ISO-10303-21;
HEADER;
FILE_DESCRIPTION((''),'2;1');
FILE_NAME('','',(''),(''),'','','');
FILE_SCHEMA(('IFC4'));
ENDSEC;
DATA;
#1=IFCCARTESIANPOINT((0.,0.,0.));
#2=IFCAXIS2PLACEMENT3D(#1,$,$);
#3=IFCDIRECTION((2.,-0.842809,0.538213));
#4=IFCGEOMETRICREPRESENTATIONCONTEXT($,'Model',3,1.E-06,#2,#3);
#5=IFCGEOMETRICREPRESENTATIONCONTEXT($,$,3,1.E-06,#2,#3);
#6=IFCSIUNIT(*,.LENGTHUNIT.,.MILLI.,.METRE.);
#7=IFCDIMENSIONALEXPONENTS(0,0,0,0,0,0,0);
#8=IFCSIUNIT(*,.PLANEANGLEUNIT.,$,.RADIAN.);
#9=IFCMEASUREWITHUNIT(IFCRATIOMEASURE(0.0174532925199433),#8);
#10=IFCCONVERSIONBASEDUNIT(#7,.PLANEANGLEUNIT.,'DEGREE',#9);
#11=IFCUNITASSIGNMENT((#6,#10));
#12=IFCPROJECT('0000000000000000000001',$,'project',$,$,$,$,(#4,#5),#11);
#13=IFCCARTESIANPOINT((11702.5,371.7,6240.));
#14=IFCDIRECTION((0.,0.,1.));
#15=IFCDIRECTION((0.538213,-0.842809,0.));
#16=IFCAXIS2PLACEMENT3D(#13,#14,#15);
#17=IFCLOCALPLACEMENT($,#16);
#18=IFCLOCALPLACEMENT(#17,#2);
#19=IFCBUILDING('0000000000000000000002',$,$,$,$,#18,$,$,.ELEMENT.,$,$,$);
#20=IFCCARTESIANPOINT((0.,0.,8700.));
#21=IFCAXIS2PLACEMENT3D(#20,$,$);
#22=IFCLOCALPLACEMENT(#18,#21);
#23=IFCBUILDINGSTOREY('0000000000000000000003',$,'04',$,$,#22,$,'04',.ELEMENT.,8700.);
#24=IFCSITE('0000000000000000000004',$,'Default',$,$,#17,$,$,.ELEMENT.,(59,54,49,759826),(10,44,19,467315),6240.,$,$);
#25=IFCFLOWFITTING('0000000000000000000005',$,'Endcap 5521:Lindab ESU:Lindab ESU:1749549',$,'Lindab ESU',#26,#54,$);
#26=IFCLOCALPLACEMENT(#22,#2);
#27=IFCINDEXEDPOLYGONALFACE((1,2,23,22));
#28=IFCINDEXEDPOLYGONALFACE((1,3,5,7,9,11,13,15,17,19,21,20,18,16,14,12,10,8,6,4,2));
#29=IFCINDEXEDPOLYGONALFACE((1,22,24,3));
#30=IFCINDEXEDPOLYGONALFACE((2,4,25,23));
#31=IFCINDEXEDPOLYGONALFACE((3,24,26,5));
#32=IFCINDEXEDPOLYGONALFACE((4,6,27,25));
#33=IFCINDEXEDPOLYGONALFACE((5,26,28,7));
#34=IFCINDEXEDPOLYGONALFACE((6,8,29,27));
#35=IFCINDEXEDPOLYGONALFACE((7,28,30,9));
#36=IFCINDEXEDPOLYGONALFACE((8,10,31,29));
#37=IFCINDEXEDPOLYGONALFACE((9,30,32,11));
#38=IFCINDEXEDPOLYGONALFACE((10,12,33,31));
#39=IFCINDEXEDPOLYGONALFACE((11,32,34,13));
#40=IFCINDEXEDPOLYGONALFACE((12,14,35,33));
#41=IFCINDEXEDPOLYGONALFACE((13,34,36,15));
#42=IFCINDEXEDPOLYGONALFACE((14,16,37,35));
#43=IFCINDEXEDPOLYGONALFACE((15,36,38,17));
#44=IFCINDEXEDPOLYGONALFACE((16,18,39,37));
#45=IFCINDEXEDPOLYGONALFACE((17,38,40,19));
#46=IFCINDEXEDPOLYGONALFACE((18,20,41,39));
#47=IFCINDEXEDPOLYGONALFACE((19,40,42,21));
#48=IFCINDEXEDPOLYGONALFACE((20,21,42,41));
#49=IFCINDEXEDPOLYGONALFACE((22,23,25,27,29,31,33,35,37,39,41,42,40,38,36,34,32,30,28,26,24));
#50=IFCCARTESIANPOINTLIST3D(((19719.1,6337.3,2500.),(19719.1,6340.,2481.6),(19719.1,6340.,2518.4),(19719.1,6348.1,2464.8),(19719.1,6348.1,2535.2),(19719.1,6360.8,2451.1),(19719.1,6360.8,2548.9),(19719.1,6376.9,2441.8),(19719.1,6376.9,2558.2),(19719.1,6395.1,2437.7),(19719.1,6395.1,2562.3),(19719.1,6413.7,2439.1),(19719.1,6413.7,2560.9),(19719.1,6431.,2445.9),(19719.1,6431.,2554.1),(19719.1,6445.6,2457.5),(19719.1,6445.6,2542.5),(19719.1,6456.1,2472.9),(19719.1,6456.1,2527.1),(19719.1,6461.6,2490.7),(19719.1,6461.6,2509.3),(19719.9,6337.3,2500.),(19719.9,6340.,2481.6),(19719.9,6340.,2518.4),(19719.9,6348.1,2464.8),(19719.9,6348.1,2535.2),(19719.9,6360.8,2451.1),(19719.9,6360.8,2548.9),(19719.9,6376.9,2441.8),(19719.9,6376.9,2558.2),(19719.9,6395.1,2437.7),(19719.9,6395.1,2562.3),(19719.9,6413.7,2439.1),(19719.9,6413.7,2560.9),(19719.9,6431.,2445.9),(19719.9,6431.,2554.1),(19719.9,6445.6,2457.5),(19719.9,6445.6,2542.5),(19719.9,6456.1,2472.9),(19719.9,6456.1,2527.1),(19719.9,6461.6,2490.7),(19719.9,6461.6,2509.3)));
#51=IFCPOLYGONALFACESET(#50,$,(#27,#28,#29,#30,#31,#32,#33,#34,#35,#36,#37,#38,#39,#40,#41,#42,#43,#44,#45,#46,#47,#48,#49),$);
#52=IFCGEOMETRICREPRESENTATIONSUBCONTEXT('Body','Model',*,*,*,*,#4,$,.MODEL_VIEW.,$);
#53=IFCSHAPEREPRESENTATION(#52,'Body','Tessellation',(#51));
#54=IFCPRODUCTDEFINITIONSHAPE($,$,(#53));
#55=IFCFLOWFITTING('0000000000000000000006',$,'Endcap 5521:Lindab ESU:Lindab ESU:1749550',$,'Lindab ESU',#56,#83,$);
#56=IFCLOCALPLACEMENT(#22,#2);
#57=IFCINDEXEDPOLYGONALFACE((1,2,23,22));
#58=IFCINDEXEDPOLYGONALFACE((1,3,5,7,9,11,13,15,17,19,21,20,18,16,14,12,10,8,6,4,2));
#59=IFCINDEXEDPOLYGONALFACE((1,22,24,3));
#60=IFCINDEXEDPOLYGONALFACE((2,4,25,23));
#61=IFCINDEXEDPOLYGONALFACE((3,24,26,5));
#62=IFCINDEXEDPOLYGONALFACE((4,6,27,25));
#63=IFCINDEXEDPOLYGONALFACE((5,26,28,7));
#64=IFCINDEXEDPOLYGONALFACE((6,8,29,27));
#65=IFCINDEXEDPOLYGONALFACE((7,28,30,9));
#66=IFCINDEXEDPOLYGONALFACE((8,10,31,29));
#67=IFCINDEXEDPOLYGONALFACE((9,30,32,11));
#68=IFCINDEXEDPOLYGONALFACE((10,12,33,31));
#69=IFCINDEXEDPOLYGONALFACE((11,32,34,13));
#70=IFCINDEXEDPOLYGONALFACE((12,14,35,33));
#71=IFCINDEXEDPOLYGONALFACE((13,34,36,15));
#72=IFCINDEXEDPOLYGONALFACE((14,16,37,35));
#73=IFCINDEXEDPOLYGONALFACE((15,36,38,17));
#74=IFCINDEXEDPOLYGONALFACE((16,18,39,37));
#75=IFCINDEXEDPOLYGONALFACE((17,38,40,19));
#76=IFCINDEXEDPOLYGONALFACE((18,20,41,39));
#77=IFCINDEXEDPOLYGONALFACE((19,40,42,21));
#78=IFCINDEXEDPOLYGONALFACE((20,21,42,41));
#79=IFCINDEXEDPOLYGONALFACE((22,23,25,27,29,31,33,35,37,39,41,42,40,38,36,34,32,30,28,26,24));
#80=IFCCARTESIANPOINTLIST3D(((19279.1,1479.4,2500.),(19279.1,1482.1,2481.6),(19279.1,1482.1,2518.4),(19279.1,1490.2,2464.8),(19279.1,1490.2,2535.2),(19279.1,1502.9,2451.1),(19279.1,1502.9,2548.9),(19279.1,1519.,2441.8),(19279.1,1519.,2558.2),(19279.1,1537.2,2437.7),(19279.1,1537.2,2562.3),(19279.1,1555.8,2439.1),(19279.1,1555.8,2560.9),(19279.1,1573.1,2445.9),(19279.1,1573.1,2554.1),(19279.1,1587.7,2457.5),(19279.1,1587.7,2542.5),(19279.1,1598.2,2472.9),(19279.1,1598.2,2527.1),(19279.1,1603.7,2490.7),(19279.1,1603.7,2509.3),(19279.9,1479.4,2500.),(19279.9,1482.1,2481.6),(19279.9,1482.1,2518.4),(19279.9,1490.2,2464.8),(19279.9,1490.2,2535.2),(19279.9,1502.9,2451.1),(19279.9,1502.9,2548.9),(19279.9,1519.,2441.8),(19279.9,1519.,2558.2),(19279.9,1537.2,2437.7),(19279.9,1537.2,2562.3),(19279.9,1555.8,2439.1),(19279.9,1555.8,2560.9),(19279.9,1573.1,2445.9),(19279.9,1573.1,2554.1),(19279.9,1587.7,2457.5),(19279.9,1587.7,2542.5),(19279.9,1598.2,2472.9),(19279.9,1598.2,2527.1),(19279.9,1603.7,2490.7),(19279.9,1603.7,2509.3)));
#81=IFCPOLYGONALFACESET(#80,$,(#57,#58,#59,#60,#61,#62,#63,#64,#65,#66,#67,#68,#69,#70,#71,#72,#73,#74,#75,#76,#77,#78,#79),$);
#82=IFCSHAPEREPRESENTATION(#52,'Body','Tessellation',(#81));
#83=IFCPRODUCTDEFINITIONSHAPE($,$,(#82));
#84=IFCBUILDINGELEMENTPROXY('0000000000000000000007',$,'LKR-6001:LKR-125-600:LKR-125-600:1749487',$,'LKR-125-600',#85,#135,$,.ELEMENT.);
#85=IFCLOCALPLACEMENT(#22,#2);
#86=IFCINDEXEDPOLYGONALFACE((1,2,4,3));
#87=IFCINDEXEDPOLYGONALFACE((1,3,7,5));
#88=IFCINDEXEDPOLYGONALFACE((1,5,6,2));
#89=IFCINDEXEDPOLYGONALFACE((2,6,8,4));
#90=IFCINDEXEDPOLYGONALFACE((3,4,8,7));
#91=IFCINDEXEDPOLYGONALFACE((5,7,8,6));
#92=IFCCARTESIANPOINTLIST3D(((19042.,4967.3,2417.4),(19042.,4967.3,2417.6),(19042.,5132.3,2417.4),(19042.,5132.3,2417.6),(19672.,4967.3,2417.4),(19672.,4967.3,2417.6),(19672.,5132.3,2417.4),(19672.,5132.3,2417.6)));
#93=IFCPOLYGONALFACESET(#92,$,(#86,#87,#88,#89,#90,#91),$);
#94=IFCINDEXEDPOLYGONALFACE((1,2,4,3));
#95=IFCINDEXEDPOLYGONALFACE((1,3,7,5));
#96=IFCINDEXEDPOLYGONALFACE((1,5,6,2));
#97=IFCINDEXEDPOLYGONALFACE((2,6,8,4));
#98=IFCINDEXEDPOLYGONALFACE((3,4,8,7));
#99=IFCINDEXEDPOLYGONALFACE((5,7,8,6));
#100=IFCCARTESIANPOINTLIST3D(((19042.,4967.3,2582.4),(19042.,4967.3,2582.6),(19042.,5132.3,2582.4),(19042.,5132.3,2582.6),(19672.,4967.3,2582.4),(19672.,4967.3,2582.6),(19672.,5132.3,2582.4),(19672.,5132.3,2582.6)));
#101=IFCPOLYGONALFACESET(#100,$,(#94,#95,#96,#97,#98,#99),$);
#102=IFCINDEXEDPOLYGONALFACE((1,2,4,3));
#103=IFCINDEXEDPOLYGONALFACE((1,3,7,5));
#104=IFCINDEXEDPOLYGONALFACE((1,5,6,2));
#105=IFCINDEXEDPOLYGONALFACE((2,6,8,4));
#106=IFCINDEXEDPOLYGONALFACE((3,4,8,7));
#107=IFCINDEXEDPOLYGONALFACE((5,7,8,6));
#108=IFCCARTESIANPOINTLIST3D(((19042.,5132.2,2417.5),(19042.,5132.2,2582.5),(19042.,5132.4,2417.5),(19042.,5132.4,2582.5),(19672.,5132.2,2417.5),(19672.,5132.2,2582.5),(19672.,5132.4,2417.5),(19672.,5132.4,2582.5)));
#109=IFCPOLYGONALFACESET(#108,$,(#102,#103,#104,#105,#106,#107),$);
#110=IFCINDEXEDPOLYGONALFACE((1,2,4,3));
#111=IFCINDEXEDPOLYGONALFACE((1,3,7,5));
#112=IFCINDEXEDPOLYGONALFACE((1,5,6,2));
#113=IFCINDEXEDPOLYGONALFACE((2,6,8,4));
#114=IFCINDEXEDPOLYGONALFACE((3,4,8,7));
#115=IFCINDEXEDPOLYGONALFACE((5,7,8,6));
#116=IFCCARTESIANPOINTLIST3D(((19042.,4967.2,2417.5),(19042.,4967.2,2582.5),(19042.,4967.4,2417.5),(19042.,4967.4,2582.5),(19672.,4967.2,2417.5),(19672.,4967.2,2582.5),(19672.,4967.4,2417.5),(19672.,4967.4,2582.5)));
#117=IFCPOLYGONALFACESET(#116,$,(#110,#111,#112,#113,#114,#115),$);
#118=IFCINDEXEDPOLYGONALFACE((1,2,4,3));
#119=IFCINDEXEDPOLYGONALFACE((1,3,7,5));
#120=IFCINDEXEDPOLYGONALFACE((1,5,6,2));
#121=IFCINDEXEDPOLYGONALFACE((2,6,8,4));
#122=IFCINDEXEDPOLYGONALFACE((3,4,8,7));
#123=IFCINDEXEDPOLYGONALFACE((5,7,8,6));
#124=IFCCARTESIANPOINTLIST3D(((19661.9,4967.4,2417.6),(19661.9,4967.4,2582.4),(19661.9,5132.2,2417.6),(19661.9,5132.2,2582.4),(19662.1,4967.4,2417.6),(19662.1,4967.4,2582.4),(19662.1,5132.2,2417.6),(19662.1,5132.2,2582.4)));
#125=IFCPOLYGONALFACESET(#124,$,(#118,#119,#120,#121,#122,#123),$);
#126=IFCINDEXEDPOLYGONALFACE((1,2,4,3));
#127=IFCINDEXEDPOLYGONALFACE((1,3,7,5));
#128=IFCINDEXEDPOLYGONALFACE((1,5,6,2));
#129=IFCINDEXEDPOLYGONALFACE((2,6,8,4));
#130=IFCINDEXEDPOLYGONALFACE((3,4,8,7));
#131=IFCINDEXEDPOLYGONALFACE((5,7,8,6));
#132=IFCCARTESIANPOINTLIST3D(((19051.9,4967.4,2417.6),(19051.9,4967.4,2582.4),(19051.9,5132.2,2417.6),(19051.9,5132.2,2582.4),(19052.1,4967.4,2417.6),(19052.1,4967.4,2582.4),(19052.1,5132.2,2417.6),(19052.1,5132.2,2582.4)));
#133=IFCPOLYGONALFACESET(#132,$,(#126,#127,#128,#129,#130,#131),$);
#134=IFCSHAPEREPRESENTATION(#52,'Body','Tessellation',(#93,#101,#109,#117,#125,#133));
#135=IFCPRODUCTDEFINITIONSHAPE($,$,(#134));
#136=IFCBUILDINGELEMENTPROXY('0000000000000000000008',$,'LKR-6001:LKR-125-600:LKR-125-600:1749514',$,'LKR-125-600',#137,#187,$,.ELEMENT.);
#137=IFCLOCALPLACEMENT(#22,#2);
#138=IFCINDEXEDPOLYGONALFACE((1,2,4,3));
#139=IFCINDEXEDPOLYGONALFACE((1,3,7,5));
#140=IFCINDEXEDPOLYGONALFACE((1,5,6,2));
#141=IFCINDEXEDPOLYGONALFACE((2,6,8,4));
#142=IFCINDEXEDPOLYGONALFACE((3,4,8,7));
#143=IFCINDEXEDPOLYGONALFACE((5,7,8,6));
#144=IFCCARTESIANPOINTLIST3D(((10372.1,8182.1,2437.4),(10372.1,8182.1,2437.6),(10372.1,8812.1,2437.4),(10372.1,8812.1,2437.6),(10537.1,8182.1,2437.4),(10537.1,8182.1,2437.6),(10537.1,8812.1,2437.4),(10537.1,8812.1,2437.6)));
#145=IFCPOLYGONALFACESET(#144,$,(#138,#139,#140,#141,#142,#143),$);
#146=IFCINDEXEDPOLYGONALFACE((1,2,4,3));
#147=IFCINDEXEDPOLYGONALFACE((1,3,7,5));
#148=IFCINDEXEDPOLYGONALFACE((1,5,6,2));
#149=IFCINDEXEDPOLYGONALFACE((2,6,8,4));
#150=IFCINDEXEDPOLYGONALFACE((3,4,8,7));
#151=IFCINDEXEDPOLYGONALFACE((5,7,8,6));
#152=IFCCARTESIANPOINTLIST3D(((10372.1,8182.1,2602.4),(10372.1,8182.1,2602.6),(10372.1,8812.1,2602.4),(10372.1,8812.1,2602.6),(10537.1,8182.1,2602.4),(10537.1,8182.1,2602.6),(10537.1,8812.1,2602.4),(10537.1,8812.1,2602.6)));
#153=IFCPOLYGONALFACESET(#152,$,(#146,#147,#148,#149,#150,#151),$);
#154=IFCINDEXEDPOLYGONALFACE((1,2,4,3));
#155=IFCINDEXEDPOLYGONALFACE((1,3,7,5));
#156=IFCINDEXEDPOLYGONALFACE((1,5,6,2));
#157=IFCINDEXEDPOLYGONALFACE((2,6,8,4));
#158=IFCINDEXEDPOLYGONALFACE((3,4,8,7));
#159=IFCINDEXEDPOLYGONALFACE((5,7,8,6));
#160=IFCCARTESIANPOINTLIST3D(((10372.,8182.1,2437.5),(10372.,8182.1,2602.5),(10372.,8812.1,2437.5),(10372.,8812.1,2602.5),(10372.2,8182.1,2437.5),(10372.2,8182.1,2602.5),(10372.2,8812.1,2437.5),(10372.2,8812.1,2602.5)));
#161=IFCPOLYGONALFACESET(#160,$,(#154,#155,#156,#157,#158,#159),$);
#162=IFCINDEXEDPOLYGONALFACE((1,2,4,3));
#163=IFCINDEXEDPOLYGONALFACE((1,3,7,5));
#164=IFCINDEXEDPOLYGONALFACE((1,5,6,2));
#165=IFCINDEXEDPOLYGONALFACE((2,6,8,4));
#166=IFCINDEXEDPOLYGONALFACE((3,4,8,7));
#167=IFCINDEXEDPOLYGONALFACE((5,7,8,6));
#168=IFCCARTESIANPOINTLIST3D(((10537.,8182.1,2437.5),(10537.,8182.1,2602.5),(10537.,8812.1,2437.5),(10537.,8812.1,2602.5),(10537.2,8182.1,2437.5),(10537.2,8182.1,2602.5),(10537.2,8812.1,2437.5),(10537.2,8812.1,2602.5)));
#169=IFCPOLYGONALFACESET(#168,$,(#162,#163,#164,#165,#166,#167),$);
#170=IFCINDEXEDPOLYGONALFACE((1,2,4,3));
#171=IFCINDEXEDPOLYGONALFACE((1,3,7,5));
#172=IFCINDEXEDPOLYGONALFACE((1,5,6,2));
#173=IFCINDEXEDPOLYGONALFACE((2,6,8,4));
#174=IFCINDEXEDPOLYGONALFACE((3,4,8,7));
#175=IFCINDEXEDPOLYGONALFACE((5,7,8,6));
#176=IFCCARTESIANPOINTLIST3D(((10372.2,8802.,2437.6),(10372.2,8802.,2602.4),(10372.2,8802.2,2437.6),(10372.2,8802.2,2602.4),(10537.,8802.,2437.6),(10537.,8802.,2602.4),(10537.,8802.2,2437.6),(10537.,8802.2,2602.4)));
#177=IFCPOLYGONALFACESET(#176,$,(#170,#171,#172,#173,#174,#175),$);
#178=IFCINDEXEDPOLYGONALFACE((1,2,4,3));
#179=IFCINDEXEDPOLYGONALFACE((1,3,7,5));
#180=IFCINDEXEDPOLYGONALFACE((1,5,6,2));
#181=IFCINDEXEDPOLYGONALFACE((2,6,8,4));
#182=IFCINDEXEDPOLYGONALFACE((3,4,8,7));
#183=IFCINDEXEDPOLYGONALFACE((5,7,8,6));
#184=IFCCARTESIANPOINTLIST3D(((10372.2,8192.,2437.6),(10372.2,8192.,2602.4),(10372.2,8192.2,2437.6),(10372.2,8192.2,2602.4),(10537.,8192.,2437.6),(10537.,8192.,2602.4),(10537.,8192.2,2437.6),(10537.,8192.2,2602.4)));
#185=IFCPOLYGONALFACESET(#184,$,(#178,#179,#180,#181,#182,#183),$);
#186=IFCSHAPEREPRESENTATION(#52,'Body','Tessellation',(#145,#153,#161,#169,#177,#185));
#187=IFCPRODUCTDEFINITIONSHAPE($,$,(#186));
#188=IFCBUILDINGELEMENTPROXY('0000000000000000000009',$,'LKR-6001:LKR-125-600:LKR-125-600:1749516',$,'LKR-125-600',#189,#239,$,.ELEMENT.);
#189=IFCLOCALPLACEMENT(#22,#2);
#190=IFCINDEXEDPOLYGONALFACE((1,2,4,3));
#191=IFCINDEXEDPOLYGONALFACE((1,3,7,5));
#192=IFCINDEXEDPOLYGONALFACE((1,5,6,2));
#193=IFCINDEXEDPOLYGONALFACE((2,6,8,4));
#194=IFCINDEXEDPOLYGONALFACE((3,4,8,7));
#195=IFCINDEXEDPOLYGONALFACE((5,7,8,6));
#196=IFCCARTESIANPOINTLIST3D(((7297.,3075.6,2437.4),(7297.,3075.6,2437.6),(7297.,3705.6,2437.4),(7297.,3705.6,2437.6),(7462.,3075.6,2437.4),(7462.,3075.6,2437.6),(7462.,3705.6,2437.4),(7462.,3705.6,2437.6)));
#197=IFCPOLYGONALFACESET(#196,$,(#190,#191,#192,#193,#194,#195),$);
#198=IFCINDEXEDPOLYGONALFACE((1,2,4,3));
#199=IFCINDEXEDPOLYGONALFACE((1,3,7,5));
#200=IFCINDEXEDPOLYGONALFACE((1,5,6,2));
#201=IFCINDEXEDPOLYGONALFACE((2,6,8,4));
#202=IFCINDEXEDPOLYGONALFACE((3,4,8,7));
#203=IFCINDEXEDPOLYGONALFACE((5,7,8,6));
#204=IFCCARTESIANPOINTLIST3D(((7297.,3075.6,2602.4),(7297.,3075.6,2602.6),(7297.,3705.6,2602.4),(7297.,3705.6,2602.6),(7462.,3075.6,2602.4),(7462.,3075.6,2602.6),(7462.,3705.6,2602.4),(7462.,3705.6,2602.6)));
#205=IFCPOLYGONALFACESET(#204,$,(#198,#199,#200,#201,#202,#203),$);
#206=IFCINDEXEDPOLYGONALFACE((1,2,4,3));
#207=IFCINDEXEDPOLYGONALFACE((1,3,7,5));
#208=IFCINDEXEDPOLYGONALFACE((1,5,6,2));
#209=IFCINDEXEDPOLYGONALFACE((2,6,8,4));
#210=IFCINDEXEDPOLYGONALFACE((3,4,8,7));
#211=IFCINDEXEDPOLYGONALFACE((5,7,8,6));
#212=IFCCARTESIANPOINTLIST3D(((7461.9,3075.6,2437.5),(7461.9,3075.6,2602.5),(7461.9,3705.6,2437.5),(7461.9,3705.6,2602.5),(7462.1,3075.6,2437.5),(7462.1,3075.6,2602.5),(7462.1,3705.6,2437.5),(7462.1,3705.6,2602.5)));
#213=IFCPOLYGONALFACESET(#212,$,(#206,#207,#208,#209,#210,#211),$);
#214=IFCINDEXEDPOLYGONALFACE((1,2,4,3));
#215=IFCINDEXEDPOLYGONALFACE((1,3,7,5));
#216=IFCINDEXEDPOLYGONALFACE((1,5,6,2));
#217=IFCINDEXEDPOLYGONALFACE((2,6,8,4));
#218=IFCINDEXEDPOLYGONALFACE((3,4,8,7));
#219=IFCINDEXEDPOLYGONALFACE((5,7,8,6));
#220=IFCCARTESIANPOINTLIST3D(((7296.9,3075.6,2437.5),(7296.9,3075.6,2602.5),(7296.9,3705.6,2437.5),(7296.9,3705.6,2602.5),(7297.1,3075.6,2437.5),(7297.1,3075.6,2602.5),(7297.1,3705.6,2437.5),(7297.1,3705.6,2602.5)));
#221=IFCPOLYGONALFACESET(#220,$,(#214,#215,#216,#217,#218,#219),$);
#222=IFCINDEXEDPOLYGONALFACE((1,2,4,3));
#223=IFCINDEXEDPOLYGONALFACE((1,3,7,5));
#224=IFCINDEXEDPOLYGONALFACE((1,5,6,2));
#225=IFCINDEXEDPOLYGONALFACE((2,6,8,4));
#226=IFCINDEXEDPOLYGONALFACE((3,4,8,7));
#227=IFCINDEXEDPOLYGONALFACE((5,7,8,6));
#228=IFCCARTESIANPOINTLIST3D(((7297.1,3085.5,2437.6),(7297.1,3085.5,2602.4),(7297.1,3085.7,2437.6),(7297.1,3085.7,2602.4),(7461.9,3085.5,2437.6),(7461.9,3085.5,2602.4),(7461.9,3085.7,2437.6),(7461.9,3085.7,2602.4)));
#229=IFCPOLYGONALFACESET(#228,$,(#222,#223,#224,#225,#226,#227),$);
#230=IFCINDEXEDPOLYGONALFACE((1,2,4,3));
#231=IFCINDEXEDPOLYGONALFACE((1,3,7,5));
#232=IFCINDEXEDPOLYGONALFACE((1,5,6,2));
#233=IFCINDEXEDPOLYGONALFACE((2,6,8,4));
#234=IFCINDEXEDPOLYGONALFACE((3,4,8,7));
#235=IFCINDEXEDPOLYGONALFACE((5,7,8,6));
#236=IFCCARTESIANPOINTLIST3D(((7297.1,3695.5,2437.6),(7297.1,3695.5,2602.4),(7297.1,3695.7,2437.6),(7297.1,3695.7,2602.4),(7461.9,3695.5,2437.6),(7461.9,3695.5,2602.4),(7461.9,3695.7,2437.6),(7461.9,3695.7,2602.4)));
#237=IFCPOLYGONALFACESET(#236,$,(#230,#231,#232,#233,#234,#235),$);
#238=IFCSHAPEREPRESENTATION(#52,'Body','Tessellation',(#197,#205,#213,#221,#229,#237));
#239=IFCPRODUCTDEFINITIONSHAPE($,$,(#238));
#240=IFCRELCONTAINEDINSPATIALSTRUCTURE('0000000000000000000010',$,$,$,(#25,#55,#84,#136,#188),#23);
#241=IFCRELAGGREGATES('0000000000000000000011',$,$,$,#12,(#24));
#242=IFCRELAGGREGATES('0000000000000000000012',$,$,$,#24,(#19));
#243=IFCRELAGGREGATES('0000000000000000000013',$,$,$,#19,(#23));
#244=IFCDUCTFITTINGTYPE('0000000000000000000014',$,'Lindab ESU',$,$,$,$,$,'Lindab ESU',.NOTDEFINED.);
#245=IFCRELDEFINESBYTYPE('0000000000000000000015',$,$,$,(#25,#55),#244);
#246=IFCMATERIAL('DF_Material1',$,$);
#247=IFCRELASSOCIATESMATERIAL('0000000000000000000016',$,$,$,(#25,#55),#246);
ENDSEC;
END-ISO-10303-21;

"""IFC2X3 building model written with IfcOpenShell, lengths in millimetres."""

from ifc_helpers import new_model, entity, si_unit, converted_unit, direction, frame, frame_2d, origin, place, context, subcontext, project, spatial, rectangle, circle, extrude, source, transform, mapped, material, type_object, type_shapes, element, save


model = new_model("IFC2X3")

# Units and contexts
model_context = context("Model", 3, precision=1e-06, world=origin(), true_north=direction((2.0, -0.842809, 0.538213)))
context_of_model = context(None, 3, precision=1e-06, world=origin(), true_north=direction((2.0, -0.842809, 0.538213)))
body_context = subcontext(model_context, "Body", "Model", "MODEL_VIEW")
ifc_project = project(units=[si_unit("LENGTHUNIT", "METRE", prefix="MILLI"), converted_unit("PLANEANGLEUNIT", "DEGREE", entity("IfcRatioMeasure", 0.0174532925199433), si_unit("PLANEANGLEUNIT", "RADIAN"), dimensions=[0, 0, 0, 0, 0, 0, 0])], contexts=[model_context, context_of_model])

# Site, building, storey
site_placement = place(None, frame((11702.5, 371.7, 6240.0), z_axis=(0.0, 0.0, 1.0), x_axis=(0.538213, -0.842809, 0.0)))
site = spatial("IfcSite", under=ifc_project, at=site_placement, Name="Default", CompositionType="ELEMENT", RefLatitude=(59, 54, 49, 759826), RefLongitude=(10, 44, 19, 467315), RefElevation=6240.0)
building_placement = place(site_placement, origin())
building = spatial("IfcBuilding", under=site, at=building_placement, CompositionType="ELEMENT")
storey_placement = place(building_placement, frame((0.0, 0.0, 8700.0)))
storey = spatial("IfcBuildingStorey", under=building, at=storey_placement, Name="04", LongName="04", CompositionType="ELEMENT", Elevation=8700.0)

# Flow fittings
ifc_material = material(Name="DF_Material1")
duct_fitting_type = type_object("IfcDuctFittingType", Name="Lindab ESU", ElementType="Lindab ESU", PredefinedType="NOTDEFINED")
shared_shape_1 = source(origin(), body_context, "Body", "SweptSolid", [
    extrude(circle(Radius=62.5, at=frame_2d((0.0, 0.0), x_axis=(1.0, 0.0))), frame((0.0, 0.0, 0.0), z_axis=(1.0, 0.0, 0.0), x_axis=(0.0, 1.0, 0.0)), (0.0, 0.0, 1.0), 0.8),
])
type_shapes(duct_fitting_type, [shared_shape_1])
for number, where, z_axis, x_axis, name in (
    (1, (19719.9, 6399.8, 2500.0), (0.0, 0.0, 1.0), (-1.0, 0.0, 0.0), "Endcap 5521:Lindab ESU:Lindab ESU:1749549"),
    (2, (19279.9, 1541.9, 2500.0), (0.0, 0.0, 1.0), (-1.0, 0.0, 0.0), "Endcap 5521:Lindab ESU:Lindab ESU:1749550"),
):
    element("IfcFlowFitting", number, at=place(storey_placement, frame(where, z_axis=z_axis, x_axis=x_axis)), inside=storey, type_object=duct_fitting_type, material=ifc_material, Name=name, ObjectType="Lindab ESU", context=body_context, shape_type="MappedRepresentation", body=[
        mapped(shared_shape_1, transform((0.0, 0.0, 0.0), scale=1.0)),
    ])

# Building element proxies
shared_shape_2 = source(origin(), body_context, "Body", "SweptSolid", [
    extrude(rectangle(XDim=165.0, YDim=630.0, at=frame_2d((0.0, 0.0), x_axis=(1.0, 0.0))), frame((0.0, 0.0, -82.6), z_axis=(0.0, 0.0, 1.0), x_axis=(0.0, -1.0, 0.0)), (0.0, 0.0, 1.0), 0.2),
    extrude(rectangle(XDim=165.0, YDim=630.0, at=frame_2d((0.0, 0.0), x_axis=(1.0, 0.0))), frame((0.0, 0.0, 82.4), z_axis=(0.0, 0.0, 1.0), x_axis=(0.0, -1.0, 0.0)), (0.0, 0.0, 1.0), 0.2),
    extrude(rectangle(XDim=0.2, YDim=630.0, at=frame_2d((0.0, 0.0), x_axis=(1.0, 0.0))), frame((0.0, 82.5, -82.5), z_axis=(0.0, 0.0, 1.0), x_axis=(0.0, 1.0, 0.0)), (0.0, 0.0, 1.0), 165.0),
    extrude(rectangle(XDim=0.2, YDim=630.0, at=frame_2d((0.0, 0.0), x_axis=(1.0, 0.0))), frame((0.0, -82.5, -82.5), z_axis=(0.0, 0.0, 1.0), x_axis=(0.0, 1.0, 0.0)), (0.0, 0.0, 1.0), 165.0),
    extrude(rectangle(XDim=0.2, YDim=164.8, at=frame_2d((0.0, 0.0), x_axis=(1.0, 0.0))), frame((305.0, 0.0, -82.4)), (0.0, 0.0, 1.0), 164.8),
    extrude(rectangle(XDim=0.2, YDim=164.8, at=frame_2d((0.0, 0.0), x_axis=(1.0, 0.0))), frame((-305.0, 0.0, -82.4)), (0.0, 0.0, 1.0), 164.8),
])
proxy_1_placement = place(storey_placement, frame((19357.0, 5049.8, 2500.0)))
element("IfcBuildingElementProxy", 3, at=proxy_1_placement, inside=storey, Name="LKR-6001:LKR-125-600:LKR-125-600:1749487", ObjectType="LKR-125-600", CompositionType="ELEMENT", context=body_context, shape_type="MappedRepresentation", body=[
    mapped(shared_shape_2, transform((0.0, 0.0, 0.0), scale=1.0)),
])
for number, where, z_axis, x_axis, name in (
    (4, (10454.6, 8497.1, 2520.0), (0.0, 0.0, 1.0), (0.0, 1.0, 0.0), "LKR-6001:LKR-125-600:LKR-125-600:1749514"),
    (5, (7379.5, 3390.6, 2520.0), (0.0, 0.0, 1.0), (0.0, -1.0, 0.0), "LKR-6001:LKR-125-600:LKR-125-600:1749516"),
):
    element("IfcBuildingElementProxy", number, at=place(storey_placement, frame(where, z_axis=z_axis, x_axis=x_axis)), inside=storey, Name=name, ObjectType="LKR-125-600", CompositionType="ELEMENT", context=body_context, shape_type="MappedRepresentation", body=[
        mapped(shared_shape_2, transform((0.0, 0.0, 0.0), scale=1.0)),
    ])

save(model, "model.ifc")
